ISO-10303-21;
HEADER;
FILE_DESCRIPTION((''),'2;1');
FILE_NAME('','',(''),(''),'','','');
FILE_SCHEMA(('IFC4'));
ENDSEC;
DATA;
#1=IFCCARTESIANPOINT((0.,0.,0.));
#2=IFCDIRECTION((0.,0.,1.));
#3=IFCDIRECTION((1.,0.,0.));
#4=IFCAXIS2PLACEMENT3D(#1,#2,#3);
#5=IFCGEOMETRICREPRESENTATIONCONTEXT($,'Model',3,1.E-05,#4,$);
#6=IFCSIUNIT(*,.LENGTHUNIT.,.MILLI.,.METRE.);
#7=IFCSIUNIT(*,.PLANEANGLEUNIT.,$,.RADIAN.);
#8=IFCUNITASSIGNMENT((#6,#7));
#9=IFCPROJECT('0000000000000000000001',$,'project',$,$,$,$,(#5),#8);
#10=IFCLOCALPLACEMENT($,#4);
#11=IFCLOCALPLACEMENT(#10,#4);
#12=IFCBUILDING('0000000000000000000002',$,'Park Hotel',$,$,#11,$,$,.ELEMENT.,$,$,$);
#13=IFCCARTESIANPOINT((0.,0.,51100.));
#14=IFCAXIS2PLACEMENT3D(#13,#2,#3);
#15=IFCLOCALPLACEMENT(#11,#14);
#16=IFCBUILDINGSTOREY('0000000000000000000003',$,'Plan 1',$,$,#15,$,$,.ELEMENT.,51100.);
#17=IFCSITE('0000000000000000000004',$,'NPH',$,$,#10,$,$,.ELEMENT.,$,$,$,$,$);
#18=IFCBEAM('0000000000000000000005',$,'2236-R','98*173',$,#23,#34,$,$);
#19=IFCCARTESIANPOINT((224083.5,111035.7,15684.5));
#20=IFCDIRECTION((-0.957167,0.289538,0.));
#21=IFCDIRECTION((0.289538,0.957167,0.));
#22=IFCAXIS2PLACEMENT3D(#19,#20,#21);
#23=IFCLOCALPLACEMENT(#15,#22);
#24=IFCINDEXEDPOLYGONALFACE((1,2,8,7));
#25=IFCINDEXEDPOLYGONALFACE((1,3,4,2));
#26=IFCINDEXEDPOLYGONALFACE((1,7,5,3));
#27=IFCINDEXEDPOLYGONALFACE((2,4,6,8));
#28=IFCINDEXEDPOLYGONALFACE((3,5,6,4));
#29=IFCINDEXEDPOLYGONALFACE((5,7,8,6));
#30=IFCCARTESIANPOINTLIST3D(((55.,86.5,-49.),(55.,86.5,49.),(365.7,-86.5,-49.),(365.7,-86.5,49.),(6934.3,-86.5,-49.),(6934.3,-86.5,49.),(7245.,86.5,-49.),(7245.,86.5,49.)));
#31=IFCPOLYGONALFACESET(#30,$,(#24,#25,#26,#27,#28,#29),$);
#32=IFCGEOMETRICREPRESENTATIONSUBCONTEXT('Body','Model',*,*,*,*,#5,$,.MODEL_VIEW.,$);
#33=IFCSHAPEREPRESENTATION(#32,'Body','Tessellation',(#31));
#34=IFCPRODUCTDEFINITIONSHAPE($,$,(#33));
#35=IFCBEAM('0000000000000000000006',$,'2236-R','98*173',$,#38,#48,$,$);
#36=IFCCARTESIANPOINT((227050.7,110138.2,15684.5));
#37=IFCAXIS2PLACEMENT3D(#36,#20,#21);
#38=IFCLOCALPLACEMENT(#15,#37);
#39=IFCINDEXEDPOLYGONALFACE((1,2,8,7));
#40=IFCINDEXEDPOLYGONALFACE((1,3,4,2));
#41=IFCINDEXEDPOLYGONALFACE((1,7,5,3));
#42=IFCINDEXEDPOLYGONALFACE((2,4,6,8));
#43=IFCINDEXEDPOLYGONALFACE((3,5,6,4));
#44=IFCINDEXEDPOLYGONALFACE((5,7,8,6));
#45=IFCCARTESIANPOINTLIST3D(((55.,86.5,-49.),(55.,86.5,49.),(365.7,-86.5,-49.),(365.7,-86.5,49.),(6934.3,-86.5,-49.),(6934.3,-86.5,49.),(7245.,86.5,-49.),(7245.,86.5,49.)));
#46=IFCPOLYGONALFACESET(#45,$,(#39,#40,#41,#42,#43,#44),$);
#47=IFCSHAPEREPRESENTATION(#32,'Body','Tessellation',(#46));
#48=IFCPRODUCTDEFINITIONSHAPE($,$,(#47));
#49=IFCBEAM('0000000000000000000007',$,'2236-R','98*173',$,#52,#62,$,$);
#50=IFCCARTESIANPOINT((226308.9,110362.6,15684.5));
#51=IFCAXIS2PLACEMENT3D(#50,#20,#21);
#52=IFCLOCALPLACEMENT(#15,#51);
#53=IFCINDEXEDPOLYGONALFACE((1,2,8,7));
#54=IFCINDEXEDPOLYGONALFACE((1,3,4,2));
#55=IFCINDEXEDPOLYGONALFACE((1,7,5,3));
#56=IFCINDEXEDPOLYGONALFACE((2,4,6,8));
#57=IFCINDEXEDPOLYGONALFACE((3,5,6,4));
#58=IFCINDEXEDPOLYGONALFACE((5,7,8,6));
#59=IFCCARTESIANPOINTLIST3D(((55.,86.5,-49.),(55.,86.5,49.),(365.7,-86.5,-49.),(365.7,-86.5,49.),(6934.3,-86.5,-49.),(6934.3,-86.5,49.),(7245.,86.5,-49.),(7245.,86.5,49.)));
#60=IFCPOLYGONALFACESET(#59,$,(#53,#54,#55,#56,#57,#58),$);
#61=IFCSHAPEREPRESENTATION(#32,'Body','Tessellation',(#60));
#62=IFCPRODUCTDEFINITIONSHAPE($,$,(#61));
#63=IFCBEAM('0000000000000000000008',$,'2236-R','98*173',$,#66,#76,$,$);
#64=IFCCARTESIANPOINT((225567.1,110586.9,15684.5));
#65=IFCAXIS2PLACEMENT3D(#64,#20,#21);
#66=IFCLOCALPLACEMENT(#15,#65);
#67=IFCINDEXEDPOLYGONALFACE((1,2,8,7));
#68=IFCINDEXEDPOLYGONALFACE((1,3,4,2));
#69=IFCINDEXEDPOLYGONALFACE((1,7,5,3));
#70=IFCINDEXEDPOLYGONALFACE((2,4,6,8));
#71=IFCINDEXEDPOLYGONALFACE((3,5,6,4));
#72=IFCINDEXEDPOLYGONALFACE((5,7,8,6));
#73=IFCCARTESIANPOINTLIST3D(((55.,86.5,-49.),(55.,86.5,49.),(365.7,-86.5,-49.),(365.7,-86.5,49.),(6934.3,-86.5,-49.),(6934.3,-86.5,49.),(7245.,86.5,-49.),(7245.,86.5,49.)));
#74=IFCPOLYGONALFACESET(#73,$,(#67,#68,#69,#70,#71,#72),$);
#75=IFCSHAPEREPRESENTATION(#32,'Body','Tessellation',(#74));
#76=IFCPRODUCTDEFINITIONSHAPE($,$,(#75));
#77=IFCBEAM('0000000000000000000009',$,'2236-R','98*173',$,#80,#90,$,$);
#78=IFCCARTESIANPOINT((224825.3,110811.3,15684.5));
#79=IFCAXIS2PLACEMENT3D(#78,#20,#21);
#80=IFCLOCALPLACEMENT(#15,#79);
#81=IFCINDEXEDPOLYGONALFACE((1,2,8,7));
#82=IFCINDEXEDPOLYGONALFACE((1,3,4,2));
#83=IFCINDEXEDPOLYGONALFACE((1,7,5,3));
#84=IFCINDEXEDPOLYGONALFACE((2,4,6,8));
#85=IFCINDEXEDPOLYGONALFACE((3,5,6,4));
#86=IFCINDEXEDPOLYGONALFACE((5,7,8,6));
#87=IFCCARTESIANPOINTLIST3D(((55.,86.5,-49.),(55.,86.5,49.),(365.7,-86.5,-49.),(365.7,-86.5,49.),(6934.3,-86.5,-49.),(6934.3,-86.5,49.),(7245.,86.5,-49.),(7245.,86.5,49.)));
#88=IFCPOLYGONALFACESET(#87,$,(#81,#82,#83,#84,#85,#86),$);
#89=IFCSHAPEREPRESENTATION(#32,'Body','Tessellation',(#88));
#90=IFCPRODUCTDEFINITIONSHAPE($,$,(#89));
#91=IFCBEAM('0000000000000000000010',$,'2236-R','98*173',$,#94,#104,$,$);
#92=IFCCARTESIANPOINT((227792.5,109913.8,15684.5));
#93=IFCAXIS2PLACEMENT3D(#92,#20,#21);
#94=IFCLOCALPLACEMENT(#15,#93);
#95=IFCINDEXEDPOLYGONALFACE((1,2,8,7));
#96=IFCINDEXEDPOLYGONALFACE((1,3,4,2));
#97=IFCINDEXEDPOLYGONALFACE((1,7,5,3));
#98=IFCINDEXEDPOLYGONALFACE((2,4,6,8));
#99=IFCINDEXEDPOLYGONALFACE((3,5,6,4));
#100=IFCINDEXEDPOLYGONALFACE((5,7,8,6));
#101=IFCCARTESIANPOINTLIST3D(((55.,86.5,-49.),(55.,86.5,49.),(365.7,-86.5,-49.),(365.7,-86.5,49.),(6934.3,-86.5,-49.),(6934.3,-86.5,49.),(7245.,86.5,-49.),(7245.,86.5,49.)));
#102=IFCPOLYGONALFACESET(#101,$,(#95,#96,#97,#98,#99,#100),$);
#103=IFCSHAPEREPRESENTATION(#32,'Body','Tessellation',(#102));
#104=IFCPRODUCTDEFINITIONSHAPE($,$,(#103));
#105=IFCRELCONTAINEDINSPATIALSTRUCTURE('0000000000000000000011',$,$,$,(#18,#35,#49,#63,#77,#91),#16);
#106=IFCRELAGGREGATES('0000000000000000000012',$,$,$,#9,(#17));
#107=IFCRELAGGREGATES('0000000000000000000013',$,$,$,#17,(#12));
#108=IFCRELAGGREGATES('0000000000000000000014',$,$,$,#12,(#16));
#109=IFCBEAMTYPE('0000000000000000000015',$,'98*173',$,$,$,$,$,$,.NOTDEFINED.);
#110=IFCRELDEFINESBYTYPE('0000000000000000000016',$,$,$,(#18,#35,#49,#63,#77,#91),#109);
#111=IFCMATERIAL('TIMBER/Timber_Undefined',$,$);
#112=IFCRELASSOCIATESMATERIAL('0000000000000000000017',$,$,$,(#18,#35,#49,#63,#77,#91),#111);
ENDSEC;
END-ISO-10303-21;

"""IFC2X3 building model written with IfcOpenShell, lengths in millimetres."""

from ifc_helpers import new_model, si_unit, frame, origin_with_axes, origin_2d_with_axis, place, context, subcontext, project, spatial, rectangle, extrude, clip, halfspace, material, type_object, element, save


model = new_model("IFC2X3")

# Units and contexts
model_context = context("Model", 3, precision=1e-05, world=origin_with_axes())
body_context = subcontext(model_context, "Body", "Model", "MODEL_VIEW")
ifc_project = project(units=[si_unit("LENGTHUNIT", "METRE", prefix="MILLI"), si_unit("PLANEANGLEUNIT", "RADIAN")], contexts=[model_context])

# Site, building, storey
site_placement = place(None, origin_with_axes())
site = spatial("IfcSite", under=ifc_project, at=site_placement, Name="NPH", CompositionType="ELEMENT")
building_placement = place(site_placement, origin_with_axes())
building = spatial("IfcBuilding", under=site, at=building_placement, Name="Park Hotel", CompositionType="ELEMENT")
storey_placement = place(building_placement, frame((0.0, 0.0, 51100.0), z_axis=(0.0, 0.0, 1.0), x_axis=(1.0, 0.0, 0.0)))
storey = spatial("IfcBuildingStorey", under=building, at=storey_placement, Name="Plan 1", CompositionType="ELEMENT", Elevation=51100.0)

# Shared definitions
ifc_material_1 = material(Name="TIMBER/Timber_Undefined")

# Beams
beam_type_1 = type_object("IfcBeamType", Name="98*173", PredefinedType="NOTDEFINED")
for number, where, z_axis, x_axis, name in (
    (1, (224083.5, 111035.7, 15684.5), (-0.957167, 0.289538, 0.0), (0.289538, 0.957167, 0.0), "2236-R"),
    (2, (227050.7, 110138.2, 15684.5), (-0.957167, 0.289538, 0.0), (0.289538, 0.957167, 0.0), "2236-R"),
    (3, (226308.9, 110362.6, 15684.5), (-0.957167, 0.289538, 0.0), (0.289538, 0.957167, 0.0), "2236-R"),
    (4, (225567.1, 110586.9, 15684.5), (-0.957167, 0.289538, 0.0), (0.289538, 0.957167, 0.0), "2236-R"),
    (5, (224825.3, 110811.3, 15684.5), (-0.957167, 0.289538, 0.0), (0.289538, 0.957167, 0.0), "2236-R"),
):
    element("IfcBeam", number, at=place(storey_placement, frame(where, z_axis=z_axis, x_axis=x_axis)), inside=storey, type_object=beam_type_1, material=ifc_material_1, Name=name, Description="98*173", context=body_context, shape_type="Clipping", body=[
        clip(clip(extrude(rectangle(XDim=173.0, YDim=98.0, at=origin_2d_with_axis()), frame((7270.0, 0.0, 0.0), z_axis=(-1.0, 0.0, 0.0), x_axis=(0.0, -1.0, 0.0)), (0.0, 0.0, 1.0), 7270.0), halfspace(frame((55.0, 86.5, -49.0), z_axis=(-0.486528, -0.873665, 0.0), x_axis=(0.0, 0.0, 1.0)), False)), halfspace(frame((7245.0, 86.5, 49.0), z_axis=(0.486529, -0.873664, 0.0), x_axis=(0.0, 0.0, -1.0)), False)),
    ])
beam_1_placement = place(storey_placement, frame((227792.5, 109913.8, 15684.5), z_axis=(-0.957167, 0.289538, 0.0), x_axis=(0.289538, 0.957167, 0.0)))
element("IfcBeam", 6, at=beam_1_placement, inside=storey, type_object=beam_type_1, material=ifc_material_1, Name="2236-R", Description="98*173", context=body_context, shape_type="Clipping", body=[
    clip(clip(extrude(rectangle(XDim=173.0, YDim=98.0, at=origin_2d_with_axis()), frame((7270.0, 0.0, 0.0), z_axis=(-1.0, 0.0, 0.0), x_axis=(0.0, -1.0, 0.0)), (0.0, 0.0, 1.0), 7270.0), halfspace(frame((55.0, 86.5, -649.0), z_axis=(-0.486528, -0.873665, 0.0), x_axis=(0.0, 0.0, 1.0)), False)), halfspace(frame((7245.0, 86.5, 49.0), z_axis=(0.486529, -0.873664, 0.0), x_axis=(0.0, 0.0, -1.0)), False)),
])

save(model, "model.ifc")
